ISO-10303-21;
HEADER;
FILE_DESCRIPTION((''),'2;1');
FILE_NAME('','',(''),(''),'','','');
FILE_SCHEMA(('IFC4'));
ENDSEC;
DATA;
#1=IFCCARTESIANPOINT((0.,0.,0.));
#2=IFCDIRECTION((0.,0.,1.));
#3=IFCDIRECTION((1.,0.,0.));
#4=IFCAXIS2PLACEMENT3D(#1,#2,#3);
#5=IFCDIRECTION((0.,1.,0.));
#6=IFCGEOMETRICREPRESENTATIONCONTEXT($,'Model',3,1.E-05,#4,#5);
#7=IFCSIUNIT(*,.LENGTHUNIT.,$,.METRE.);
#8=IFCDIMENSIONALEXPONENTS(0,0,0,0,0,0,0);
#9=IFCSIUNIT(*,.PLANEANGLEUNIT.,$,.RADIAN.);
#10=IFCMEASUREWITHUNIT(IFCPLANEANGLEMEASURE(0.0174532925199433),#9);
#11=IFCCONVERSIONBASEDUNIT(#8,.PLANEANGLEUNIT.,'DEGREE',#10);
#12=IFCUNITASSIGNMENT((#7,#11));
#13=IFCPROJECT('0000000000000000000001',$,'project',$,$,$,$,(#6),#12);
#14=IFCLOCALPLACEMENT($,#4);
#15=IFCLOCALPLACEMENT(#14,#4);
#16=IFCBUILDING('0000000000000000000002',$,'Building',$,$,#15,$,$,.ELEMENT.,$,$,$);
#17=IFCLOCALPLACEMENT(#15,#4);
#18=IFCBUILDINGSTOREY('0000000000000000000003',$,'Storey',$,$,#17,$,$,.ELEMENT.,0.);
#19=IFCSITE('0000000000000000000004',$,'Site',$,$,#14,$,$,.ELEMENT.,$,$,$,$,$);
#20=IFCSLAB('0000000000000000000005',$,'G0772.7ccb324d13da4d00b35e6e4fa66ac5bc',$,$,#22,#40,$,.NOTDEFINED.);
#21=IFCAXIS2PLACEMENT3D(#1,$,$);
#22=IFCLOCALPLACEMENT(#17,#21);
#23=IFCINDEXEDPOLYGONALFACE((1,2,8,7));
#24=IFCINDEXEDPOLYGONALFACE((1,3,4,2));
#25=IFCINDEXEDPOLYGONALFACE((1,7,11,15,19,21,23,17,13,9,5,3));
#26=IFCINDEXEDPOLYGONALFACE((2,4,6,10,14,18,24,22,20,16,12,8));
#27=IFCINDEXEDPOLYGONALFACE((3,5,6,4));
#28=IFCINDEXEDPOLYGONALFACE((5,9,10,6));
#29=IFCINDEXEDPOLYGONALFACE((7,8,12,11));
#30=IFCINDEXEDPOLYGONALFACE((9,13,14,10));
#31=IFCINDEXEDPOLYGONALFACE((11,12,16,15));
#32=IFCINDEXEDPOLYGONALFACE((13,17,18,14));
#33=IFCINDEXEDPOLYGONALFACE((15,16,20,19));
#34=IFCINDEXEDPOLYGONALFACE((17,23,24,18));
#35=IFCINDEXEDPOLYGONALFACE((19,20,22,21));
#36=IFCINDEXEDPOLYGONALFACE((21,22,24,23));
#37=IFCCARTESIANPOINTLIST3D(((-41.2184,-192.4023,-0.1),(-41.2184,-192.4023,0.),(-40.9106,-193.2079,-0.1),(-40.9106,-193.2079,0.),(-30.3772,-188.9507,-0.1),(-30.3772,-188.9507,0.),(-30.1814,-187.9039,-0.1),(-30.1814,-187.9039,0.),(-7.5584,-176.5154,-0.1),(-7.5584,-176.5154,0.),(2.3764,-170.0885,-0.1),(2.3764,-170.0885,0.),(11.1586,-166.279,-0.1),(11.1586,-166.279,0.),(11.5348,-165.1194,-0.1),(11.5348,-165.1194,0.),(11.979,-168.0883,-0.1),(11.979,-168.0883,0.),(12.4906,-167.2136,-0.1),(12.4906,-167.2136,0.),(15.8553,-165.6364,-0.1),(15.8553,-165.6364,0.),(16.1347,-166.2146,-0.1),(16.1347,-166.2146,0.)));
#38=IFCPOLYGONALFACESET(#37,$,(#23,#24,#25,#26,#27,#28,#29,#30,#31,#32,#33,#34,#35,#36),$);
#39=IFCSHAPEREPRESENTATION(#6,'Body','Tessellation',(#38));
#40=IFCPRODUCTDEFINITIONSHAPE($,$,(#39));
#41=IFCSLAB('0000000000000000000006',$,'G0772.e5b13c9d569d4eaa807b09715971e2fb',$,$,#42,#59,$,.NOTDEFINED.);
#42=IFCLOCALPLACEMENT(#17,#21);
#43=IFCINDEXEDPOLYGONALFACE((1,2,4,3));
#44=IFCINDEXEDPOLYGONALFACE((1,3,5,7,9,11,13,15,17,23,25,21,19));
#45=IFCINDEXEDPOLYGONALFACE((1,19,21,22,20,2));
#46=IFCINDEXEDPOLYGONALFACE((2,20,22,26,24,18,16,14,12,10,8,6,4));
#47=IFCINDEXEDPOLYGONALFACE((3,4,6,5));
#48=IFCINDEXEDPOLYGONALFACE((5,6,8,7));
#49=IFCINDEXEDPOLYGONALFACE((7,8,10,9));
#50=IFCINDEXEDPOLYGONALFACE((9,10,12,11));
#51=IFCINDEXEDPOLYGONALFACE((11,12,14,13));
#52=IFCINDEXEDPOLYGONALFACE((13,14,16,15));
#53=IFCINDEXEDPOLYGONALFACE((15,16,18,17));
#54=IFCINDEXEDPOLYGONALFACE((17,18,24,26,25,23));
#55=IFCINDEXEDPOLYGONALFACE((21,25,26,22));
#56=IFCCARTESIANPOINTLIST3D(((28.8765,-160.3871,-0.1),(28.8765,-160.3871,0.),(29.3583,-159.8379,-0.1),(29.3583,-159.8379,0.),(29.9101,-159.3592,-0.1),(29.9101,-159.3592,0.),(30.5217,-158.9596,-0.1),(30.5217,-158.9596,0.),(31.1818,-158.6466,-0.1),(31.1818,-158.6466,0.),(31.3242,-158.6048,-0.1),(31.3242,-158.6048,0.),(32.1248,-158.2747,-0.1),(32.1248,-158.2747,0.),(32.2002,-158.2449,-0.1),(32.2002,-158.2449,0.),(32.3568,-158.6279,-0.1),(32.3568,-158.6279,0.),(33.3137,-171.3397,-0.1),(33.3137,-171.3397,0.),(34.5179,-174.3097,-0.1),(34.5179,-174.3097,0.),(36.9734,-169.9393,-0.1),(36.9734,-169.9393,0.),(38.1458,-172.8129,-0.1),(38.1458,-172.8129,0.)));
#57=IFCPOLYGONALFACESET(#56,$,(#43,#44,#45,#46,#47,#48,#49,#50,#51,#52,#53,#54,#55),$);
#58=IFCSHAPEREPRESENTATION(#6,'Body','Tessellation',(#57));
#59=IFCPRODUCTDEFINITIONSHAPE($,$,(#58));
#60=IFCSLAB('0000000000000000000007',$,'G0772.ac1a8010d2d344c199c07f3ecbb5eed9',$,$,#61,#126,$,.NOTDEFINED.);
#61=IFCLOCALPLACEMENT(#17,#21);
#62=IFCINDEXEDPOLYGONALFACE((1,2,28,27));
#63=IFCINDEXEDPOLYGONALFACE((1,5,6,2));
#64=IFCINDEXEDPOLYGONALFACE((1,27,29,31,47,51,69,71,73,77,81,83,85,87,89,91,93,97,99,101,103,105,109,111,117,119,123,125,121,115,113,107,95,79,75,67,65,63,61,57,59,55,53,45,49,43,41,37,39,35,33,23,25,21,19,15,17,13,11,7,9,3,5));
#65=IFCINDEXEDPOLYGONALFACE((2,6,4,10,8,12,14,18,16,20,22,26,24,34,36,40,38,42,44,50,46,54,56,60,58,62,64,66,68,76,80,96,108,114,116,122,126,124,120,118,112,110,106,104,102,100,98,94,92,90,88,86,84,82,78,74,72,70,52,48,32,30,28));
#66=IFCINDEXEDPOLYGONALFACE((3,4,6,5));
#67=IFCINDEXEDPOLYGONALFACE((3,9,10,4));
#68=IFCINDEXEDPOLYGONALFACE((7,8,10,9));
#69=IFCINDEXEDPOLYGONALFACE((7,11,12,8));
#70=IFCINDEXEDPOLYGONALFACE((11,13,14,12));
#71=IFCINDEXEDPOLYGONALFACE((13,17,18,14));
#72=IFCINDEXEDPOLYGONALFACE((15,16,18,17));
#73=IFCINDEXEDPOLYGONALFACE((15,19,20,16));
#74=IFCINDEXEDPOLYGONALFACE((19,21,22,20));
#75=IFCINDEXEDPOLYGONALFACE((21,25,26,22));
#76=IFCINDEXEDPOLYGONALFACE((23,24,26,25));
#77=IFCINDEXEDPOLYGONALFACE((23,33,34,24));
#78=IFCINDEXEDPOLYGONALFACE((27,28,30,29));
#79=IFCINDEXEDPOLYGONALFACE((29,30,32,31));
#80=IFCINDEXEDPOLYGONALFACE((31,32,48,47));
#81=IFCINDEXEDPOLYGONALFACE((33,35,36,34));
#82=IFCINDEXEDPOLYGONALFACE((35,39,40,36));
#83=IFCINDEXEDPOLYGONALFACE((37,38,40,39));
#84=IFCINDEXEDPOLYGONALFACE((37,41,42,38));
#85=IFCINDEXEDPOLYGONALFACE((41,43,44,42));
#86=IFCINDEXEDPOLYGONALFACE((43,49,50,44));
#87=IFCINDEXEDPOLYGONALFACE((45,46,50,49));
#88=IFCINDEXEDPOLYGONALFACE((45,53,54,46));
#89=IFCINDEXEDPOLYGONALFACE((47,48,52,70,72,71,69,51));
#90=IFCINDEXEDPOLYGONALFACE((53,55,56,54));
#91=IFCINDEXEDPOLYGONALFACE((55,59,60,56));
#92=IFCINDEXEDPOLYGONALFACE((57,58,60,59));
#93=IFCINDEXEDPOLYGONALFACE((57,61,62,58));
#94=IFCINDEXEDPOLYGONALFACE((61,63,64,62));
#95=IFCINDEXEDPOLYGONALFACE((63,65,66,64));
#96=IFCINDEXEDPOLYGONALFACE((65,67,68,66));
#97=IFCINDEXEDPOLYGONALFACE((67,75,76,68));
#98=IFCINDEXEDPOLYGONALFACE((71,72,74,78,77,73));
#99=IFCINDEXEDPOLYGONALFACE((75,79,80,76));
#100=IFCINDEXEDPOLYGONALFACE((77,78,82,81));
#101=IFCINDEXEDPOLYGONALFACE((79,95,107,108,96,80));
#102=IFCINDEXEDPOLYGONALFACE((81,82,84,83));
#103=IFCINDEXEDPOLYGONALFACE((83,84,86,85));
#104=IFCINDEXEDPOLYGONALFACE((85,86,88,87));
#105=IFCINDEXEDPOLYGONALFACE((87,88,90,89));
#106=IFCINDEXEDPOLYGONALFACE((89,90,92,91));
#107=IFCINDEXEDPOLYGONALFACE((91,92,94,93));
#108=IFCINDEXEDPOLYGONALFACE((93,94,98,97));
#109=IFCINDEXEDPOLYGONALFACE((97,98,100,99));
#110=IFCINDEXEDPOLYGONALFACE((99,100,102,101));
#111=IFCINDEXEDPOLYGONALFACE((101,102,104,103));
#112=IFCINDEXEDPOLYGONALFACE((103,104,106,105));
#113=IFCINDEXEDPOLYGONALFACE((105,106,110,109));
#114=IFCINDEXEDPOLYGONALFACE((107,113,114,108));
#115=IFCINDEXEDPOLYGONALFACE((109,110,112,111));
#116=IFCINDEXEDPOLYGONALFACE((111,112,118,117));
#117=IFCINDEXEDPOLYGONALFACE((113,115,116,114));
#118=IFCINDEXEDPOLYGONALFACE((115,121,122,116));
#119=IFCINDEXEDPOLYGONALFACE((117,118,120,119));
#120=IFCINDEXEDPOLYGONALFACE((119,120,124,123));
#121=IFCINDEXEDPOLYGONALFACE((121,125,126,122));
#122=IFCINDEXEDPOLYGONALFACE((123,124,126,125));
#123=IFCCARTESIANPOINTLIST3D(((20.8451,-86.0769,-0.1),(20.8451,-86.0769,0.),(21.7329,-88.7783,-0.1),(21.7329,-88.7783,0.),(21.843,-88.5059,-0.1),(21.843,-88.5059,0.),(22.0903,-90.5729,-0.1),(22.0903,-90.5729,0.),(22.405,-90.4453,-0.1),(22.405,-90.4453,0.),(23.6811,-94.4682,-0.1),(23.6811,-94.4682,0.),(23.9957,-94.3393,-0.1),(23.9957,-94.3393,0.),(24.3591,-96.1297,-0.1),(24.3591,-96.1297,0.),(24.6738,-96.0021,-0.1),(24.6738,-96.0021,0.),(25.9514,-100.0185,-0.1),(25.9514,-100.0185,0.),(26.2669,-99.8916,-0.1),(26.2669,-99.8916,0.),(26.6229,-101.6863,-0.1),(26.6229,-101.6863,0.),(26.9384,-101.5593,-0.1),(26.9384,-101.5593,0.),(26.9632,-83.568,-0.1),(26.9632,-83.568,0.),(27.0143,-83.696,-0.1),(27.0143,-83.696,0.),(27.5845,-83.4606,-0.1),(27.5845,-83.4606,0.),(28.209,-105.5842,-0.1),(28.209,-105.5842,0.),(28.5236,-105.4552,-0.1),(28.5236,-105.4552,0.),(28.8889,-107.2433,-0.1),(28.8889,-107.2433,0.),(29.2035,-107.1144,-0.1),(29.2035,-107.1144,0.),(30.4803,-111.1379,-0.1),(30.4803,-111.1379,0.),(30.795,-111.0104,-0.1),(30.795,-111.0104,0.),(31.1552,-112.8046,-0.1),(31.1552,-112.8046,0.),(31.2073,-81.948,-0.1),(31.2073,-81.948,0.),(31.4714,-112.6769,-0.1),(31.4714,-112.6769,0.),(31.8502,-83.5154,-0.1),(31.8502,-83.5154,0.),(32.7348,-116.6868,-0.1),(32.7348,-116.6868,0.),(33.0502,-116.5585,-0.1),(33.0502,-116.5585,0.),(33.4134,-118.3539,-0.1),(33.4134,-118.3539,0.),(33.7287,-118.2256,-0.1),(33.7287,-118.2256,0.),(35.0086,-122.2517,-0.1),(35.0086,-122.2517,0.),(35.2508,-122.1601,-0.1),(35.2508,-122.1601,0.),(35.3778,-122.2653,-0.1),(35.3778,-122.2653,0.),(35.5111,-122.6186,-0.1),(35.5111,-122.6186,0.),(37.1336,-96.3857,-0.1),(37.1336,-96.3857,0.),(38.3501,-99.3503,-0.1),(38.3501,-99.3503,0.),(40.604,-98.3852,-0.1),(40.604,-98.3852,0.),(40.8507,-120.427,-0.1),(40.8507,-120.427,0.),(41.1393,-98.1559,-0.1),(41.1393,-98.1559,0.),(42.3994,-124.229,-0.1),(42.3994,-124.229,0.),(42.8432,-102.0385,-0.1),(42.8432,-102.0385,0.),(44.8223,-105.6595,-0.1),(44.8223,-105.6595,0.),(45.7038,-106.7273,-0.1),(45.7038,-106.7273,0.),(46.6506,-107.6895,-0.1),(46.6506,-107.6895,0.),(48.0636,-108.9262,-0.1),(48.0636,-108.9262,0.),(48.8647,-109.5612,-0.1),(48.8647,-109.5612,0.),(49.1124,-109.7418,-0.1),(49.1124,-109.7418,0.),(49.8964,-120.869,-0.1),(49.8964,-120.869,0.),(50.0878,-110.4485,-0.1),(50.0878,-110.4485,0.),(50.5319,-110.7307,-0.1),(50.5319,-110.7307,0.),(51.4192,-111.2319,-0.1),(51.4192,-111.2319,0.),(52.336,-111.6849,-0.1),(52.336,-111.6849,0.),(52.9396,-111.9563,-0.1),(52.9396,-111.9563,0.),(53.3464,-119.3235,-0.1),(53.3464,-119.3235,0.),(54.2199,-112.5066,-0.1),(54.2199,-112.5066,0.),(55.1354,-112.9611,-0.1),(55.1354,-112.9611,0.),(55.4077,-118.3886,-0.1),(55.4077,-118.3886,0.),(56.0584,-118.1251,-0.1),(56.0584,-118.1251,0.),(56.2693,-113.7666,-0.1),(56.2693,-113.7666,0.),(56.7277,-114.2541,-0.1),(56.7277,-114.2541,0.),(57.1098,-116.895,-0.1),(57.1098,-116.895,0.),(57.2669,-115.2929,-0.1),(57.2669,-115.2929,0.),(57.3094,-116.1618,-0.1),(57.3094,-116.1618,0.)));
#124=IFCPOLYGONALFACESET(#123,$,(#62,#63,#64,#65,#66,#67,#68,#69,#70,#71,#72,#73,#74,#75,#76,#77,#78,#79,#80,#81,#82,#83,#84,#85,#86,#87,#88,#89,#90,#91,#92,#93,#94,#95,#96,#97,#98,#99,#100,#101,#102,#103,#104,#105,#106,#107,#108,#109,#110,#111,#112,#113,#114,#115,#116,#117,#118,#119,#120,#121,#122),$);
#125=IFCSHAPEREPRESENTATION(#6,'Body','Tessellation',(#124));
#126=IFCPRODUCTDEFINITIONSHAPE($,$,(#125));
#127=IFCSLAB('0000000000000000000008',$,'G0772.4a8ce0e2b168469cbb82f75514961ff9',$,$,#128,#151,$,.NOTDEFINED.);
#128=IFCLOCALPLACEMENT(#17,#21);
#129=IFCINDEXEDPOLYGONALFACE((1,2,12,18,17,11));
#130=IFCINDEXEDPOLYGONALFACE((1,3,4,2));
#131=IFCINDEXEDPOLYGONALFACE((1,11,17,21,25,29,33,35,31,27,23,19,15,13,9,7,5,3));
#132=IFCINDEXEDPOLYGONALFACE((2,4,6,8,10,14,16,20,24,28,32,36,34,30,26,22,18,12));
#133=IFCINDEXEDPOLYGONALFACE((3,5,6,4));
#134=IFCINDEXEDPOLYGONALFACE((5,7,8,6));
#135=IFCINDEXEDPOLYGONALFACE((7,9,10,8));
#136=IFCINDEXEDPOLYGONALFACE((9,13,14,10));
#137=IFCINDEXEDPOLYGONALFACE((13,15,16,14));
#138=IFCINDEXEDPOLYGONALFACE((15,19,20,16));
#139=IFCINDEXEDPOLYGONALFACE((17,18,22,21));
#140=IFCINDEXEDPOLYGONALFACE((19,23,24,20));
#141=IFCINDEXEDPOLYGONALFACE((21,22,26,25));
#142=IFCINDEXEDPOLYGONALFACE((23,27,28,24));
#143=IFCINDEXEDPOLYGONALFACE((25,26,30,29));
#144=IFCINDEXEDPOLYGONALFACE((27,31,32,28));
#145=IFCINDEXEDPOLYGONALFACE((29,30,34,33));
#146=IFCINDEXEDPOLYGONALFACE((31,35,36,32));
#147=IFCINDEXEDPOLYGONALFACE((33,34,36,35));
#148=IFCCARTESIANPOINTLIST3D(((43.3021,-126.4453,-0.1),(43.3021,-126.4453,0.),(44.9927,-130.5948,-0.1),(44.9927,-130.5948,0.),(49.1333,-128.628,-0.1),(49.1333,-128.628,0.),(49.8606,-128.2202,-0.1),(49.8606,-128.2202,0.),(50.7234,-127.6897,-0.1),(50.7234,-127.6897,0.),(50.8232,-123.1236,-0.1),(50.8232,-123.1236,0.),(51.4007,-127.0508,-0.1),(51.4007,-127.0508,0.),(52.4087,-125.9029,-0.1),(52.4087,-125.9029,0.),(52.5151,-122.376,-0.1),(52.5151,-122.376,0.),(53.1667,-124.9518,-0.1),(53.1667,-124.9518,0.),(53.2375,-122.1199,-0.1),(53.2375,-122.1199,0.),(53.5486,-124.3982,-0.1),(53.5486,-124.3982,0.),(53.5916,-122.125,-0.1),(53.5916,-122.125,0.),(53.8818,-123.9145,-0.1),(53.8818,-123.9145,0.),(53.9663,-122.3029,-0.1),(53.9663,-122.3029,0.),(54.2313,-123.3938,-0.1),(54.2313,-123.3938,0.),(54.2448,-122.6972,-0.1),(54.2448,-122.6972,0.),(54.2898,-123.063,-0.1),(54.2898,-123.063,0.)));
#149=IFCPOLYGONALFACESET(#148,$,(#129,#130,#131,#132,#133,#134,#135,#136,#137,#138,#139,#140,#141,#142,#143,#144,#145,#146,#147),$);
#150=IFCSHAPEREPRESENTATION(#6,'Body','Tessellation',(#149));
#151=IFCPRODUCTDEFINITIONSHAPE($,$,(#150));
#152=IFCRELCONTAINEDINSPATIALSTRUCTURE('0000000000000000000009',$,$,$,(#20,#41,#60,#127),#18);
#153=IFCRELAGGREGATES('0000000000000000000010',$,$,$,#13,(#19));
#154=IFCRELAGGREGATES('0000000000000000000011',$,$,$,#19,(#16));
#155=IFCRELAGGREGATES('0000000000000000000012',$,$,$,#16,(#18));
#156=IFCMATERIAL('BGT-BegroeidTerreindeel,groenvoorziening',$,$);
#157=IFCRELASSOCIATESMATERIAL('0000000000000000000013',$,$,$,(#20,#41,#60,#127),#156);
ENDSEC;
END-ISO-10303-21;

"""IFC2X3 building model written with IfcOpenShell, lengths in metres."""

from ifc_helpers import new_model, entity, si_unit, converted_unit, direction, frame, origin_with_axes, place, context, project, spatial, polyline, outline, extrude, material, element, save


model = new_model("IFC2X3")

# Units and contexts
model_context = context("Model", 3, precision=1e-05, world=origin_with_axes(), true_north=direction((0.0, 1.0, 0.0)))
ifc_project = project(units=[si_unit("LENGTHUNIT", "METRE"), converted_unit("PLANEANGLEUNIT", "DEGREE", entity("IfcPlaneAngleMeasure", 0.0174532925199433), si_unit("PLANEANGLEUNIT", "RADIAN"), dimensions=[0, 0, 0, 0, 0, 0, 0])], contexts=[model_context])

# Site, building, storey
site_placement = place(None, origin_with_axes())
site = spatial("IfcSite", under=ifc_project, at=site_placement, Name="Site", CompositionType="ELEMENT")
building_placement = place(site_placement, origin_with_axes())
building = spatial("IfcBuilding", under=site, at=building_placement, Name="Building", CompositionType="ELEMENT")
storey_placement = place(building_placement, origin_with_axes())
storey = spatial("IfcBuildingStorey", under=building, at=storey_placement, Name="Storey", CompositionType="ELEMENT", Elevation=0.0)

# Slabs
ifc_material_1 = material(Name="BGT-BegroeidTerreindeel,groenvoorziening")
slab_1_placement = place(storey_placement, frame((0.0, 0.0, -0.1), z_axis=(0.0, 0.0, 1.0), x_axis=(1.0, 0.0, 0.0)))
element("IfcSlab", 1, at=slab_1_placement, inside=storey, material=ifc_material_1, Name="G0772.7ccb324d13da4d00b35e6e4fa66ac5bc", PredefinedType="NOTDEFINED", context=model_context, shape_type="SweptSolid", body=[
    extrude(outline(polyline([(2.3764, -170.0885), (11.5348, -165.1194), (12.4906, -167.2136), (15.8553, -165.6364), (16.1347, -166.2146), (11.979, -168.0883), (11.1586, -166.279), (-7.5584, -176.5154), (-30.3772, -188.9507), (-40.9106, -193.2079), (-41.2184, -192.4023), (-30.1814, -187.9039), (2.3764, -170.0885)])), origin_with_axes(), (0.0, 0.0, 1.0), 0.1),
])
slab_2_placement = place(storey_placement, frame((0.0, 0.0, -0.1), z_axis=(0.0, 0.0, 1.0), x_axis=(1.0, 0.0, 0.0)))
element("IfcSlab", 2, at=slab_2_placement, inside=storey, material=ifc_material_1, Name="G0772.e5b13c9d569d4eaa807b09715971e2fb", PredefinedType="NOTDEFINED", context=model_context, shape_type="SweptSolid", body=[
    extrude(outline(polyline([(36.9734, -169.9393), (38.1458, -172.8129), (34.5179, -174.3097), (33.3137, -171.3397), (28.8765, -160.3871), (29.3583, -159.8379), (29.9101, -159.3592), (30.5217, -158.9596), (31.1818, -158.6466), (31.3242, -158.6048), (32.1248, -158.2747), (32.2002, -158.2449), (32.3568, -158.6279), (36.9734, -169.9393)])), origin_with_axes(), (0.0, 0.0, 1.0), 0.1),
])
slab_3_placement = place(storey_placement, frame((0.0, 0.0, -0.1), z_axis=(0.0, 0.0, 1.0), x_axis=(1.0, 0.0, 0.0)))
element("IfcSlab", 3, at=slab_3_placement, inside=storey, material=ifc_material_1, Name="G0772.ac1a8010d2d344c199c07f3ecbb5eed9", PredefinedType="NOTDEFINED", context=model_context, shape_type="SweptSolid", body=[
    extrude(outline(polyline([(31.8502, -83.5154), (37.1336, -96.3857), (38.3501, -99.3503), (40.604, -98.3852), (41.1393, -98.1559), (42.8432, -102.0385), (44.8223, -105.6595), (45.7038, -106.7273), (46.6506, -107.6895), (48.0636, -108.9262), (48.8647, -109.5612), (49.1124, -109.7418), (50.0878, -110.4485), (50.5319, -110.7307), (51.4192, -111.2319), (52.336, -111.6849), (52.9396, -111.9563), (54.2199, -112.5066), (55.1354, -112.9611), (56.2693, -113.7666), (56.7277, -114.2541), (57.2669, -115.2929), (57.3094, -116.1618), (57.1098, -116.895), (56.0584, -118.1251), (55.4077, -118.3886), (53.3464, -119.3235), (49.8964, -120.869), (42.3994, -124.229), (40.8507, -120.427), (35.5111, -122.6186), (35.3778, -122.2653), (35.2508, -122.1601), (35.0086, -122.2517), (33.4134, -118.3539), (33.7287, -118.2256), (33.0502, -116.5585), (32.7348, -116.6868), (31.1552, -112.8046), (31.4714, -112.6769), (30.795, -111.0104), (30.4803, -111.1379), (28.8889, -107.2433), (29.2035, -107.1144), (28.5236, -105.4552), (28.209, -105.5842), (26.6229, -101.6863), (26.9384, -101.5593), (26.2669, -99.8916), (25.9514, -100.0185), (24.3591, -96.1297), (24.6738, -96.0021), (23.9957, -94.3393), (23.6811, -94.4682), (22.0903, -90.5729), (22.405, -90.4453), (21.7329, -88.7783), (21.843, -88.5059), (20.8451, -86.0769), (26.9632, -83.568), (27.0143, -83.696), (27.5845, -83.4606), (31.2073, -81.948), (31.8502, -83.5154)])), origin_with_axes(), (0.0, 0.0, 1.0), 0.1),
])
slab_4_placement = place(storey_placement, frame((0.0, 0.0, -0.1), z_axis=(0.0, 0.0, 1.0), x_axis=(1.0, 0.0, 0.0)))
element("IfcSlab", 4, at=slab_4_placement, inside=storey, material=ifc_material_1, Name="G0772.4a8ce0e2b168469cbb82f75514961ff9", PredefinedType="NOTDEFINED", context=model_context, shape_type="SweptSolid", body=[
    extrude(outline(polyline([(50.8232, -123.1236), (52.5151, -122.376), (53.2375, -122.1199), (53.5916, -122.125), (53.9663, -122.3029), (54.2448, -122.6972), (54.2898, -123.063), (54.2313, -123.3938), (53.8818, -123.9145), (53.5486, -124.3982), (53.1667, -124.9518), (52.4087, -125.9029), (51.4007, -127.0508), (50.7234, -127.6897), (49.8606, -128.2202), (49.1333, -128.628), (44.9927, -130.5948), (43.3021, -126.4453), (50.8232, -123.1236)])), origin_with_axes(), (0.0, 0.0, 1.0), 0.1),
])

save(model, "model.ifc")
